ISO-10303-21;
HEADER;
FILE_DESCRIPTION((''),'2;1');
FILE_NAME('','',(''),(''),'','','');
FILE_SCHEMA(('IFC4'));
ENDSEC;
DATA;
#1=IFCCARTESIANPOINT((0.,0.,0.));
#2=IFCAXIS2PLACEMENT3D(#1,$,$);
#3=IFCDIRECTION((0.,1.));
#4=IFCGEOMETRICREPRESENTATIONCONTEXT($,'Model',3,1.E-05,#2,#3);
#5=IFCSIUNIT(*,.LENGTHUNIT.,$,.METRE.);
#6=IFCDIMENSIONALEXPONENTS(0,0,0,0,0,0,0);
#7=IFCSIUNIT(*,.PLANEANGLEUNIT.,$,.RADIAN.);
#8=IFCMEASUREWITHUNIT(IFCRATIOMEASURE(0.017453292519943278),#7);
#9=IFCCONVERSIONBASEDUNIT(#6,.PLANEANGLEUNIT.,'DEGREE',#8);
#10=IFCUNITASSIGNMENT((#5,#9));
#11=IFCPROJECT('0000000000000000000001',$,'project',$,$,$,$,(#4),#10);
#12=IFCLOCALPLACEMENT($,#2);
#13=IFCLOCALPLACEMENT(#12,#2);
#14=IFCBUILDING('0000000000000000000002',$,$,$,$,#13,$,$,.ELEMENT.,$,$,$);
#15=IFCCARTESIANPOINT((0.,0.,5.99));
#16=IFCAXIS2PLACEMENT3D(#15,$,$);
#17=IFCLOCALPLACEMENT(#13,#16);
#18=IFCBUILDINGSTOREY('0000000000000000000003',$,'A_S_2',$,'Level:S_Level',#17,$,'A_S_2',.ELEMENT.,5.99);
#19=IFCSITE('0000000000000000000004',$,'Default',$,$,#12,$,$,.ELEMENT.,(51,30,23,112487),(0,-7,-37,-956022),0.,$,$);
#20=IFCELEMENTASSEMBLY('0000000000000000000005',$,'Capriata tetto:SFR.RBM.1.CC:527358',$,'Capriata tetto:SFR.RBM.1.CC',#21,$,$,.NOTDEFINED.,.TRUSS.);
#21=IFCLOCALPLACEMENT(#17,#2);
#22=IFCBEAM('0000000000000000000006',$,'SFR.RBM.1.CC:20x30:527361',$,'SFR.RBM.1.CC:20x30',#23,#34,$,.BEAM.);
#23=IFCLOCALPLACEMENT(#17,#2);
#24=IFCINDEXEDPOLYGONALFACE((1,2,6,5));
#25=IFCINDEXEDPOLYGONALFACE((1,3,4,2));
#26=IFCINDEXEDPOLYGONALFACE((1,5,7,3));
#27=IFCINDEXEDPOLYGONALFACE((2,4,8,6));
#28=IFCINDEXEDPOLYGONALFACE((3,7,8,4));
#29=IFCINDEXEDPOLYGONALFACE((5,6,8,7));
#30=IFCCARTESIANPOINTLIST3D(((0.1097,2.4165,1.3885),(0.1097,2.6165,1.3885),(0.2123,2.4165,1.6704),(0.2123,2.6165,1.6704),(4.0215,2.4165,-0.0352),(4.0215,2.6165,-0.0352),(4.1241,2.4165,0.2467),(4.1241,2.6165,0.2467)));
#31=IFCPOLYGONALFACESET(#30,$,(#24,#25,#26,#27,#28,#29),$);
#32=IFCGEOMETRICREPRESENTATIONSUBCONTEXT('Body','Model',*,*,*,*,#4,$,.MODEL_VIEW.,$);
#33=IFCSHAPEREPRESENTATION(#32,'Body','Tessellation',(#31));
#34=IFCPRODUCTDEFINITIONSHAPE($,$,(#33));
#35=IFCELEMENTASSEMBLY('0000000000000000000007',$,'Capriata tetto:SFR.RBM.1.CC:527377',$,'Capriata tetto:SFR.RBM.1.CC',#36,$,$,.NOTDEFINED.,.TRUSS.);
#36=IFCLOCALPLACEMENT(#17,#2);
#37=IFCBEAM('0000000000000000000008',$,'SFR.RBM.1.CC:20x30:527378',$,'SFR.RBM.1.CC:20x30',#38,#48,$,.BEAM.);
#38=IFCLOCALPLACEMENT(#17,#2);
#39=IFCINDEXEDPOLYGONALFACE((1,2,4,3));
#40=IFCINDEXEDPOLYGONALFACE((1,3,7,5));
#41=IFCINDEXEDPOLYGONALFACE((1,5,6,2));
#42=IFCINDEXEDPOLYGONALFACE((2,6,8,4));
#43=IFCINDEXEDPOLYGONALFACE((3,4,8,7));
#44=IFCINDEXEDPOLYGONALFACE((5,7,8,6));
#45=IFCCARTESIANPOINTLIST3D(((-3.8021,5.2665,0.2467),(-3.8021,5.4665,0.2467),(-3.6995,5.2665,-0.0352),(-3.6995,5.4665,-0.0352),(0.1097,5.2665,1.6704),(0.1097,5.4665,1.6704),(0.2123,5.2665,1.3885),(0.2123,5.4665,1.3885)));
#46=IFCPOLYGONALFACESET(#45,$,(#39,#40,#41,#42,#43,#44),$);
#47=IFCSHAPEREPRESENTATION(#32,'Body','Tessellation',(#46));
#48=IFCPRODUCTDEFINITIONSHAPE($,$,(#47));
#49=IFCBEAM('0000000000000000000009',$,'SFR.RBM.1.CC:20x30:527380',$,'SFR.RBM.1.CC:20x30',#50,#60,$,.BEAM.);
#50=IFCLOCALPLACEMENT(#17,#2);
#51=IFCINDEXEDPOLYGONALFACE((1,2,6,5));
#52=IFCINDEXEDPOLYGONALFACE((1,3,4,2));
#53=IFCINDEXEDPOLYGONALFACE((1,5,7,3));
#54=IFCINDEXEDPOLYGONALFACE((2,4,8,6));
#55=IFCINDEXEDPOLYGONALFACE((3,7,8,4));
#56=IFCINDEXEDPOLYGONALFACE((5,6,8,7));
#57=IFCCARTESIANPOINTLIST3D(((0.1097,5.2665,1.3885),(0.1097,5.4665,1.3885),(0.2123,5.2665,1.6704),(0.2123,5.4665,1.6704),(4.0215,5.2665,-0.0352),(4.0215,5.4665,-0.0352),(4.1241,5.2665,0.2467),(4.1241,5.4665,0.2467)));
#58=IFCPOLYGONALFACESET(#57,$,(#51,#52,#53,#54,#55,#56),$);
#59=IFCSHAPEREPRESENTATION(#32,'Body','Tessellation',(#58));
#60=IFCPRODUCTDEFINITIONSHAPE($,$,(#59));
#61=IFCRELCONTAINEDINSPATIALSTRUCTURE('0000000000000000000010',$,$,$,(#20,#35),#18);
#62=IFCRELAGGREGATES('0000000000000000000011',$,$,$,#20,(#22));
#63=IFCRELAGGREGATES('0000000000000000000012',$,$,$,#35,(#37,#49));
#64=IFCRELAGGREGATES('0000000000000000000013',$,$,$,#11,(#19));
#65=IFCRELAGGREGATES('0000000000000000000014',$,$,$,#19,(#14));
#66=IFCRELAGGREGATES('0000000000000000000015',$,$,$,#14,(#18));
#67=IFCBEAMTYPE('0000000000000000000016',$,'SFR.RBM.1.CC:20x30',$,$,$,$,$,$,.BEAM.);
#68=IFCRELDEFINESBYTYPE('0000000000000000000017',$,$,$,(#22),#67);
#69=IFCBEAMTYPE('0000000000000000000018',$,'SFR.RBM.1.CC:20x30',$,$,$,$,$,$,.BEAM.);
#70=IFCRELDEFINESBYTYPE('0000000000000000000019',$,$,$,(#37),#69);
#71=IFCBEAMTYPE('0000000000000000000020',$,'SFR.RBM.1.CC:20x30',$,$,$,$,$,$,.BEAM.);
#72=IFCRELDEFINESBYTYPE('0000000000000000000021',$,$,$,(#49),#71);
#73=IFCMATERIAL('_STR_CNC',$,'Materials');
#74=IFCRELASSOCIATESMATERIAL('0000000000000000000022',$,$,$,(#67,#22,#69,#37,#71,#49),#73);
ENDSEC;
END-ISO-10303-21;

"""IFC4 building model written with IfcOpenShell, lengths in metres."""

from ifc_helpers import new_model, entity, si_unit, converted_unit, direction, frame, origin, place, context, subcontext, project, spatial, indexed_curve, outline, extrude, source, transform, mapped, material, type_object, type_shapes, element, aggregate, save


model = new_model("IFC4")

# Units and contexts
model_context = context("Model", 3, precision=1e-05, world=origin(), true_north=direction((0.0, 1.0)))
body_context = subcontext(model_context, "Body", "Model", "MODEL_VIEW")
ifc_project = project(units=[si_unit("LENGTHUNIT", "METRE"), converted_unit("PLANEANGLEUNIT", "DEGREE", entity("IfcRatioMeasure", 0.017453292519943278), si_unit("PLANEANGLEUNIT", "RADIAN"), dimensions=[0, 0, 0, 0, 0, 0, 0])], contexts=[model_context])

# Site, building, storey
site_placement = place(None, origin())
site = spatial("IfcSite", under=ifc_project, at=site_placement, Name="Default", CompositionType="ELEMENT", RefLatitude=(51, 30, 23, 112487), RefLongitude=(0, -7, -37, -956022), RefElevation=0.0)
building_placement = place(site_placement, origin())
building = spatial("IfcBuilding", under=site, at=building_placement, CompositionType="ELEMENT")
storey_placement = place(building_placement, frame((0.0, 0.0, 5.99)))
storey = spatial("IfcBuildingStorey", under=building, at=storey_placement, Name="A_S_2", ObjectType="Level:S_Level", LongName="A_S_2", CompositionType="ELEMENT", Elevation=5.99)

# Shared definitions
ifc_material_1 = material(Name="_STR_CNC", Category="Materials")

# Element assemblies, beams
assembly_1_placement = place(storey_placement, origin())
assembly_1 = element("IfcElementAssembly", 1, at=assembly_1_placement, inside=storey, Name="Capriata tetto:SFR.RBM.1.CC:527358", ObjectType="Capriata tetto:SFR.RBM.1.CC", AssemblyPlace="NOTDEFINED", PredefinedType="TRUSS")
beam_type_1 = type_object("IfcBeamType", Name="SFR.RBM.1.CC:20x30", PredefinedType="BEAM", material=ifc_material_1)
shared_shape_1 = source(origin(), body_context, "Body", "SweptSolid", [
    extrude(outline(indexed_curve([(-0.1, -0.15), (0.1, -0.15), (0.1, 0.15), (-0.1, 0.15), (-0.1, -0.15)], self_intersect=False)), frame((0.161, 2.5165, 7.5195), z_axis=(0.939693, 0.0, -0.34202), x_axis=(0.0, 1.0, 0.0)), (0.0, 0.0, 1.0), 4.1628),
])
type_shapes(beam_type_1, [shared_shape_1])
beam_1_placement = place(assembly_1_placement, frame((0.0, 0.0, -5.99)))
beam_1 = element("IfcBeam", 2, at=beam_1_placement, type_object=beam_type_1, material=ifc_material_1, Name="SFR.RBM.1.CC:20x30:527361", ObjectType="SFR.RBM.1.CC:20x30", PredefinedType="BEAM", context=body_context, shape_type="MappedRepresentation", body=[
    mapped(shared_shape_1, transform((0.0, 0.0, 0.0), scale=1.0)),
])
aggregate(assembly_1, [beam_1])
assembly_2_placement = place(storey_placement, origin())
assembly_2 = element("IfcElementAssembly", 3, at=assembly_2_placement, inside=storey, Name="Capriata tetto:SFR.RBM.1.CC:527377", ObjectType="Capriata tetto:SFR.RBM.1.CC", AssemblyPlace="NOTDEFINED", PredefinedType="TRUSS")
beam_type_2 = type_object("IfcBeamType", Name="SFR.RBM.1.CC:20x30", PredefinedType="BEAM", material=ifc_material_1)
shared_shape_2 = source(origin(), body_context, "Body", "SweptSolid", [
    extrude(outline(indexed_curve([(-0.1, -0.15), (0.1, -0.15), (0.1, 0.15), (-0.1, 0.15), (-0.1, -0.15)], self_intersect=False)), frame((-3.7508, 5.3665, 6.0957), z_axis=(0.939693, 0.0, 0.34202), x_axis=(0.0, -1.0, 0.0)), (0.0, 0.0, 1.0), 4.1628),
])
type_shapes(beam_type_2, [shared_shape_2])
beam_2_placement = place(assembly_2_placement, frame((0.0, 0.0, -5.99)))
beam_2 = element("IfcBeam", 4, at=beam_2_placement, type_object=beam_type_2, material=ifc_material_1, Name="SFR.RBM.1.CC:20x30:527378", ObjectType="SFR.RBM.1.CC:20x30", PredefinedType="BEAM", context=body_context, shape_type="MappedRepresentation", body=[
    mapped(shared_shape_2, transform((0.0, 0.0, 0.0), scale=1.0)),
])
beam_type_3 = type_object("IfcBeamType", Name="SFR.RBM.1.CC:20x30", PredefinedType="BEAM", material=ifc_material_1)
shared_shape_3 = source(origin(), body_context, "Body", "SweptSolid", [
    extrude(outline(indexed_curve([(-0.1, -0.15), (0.1, -0.15), (0.1, 0.15), (-0.1, 0.15), (-0.1, -0.15)], self_intersect=False)), frame((0.161, 5.3665, 7.5195), z_axis=(0.939693, 0.0, -0.34202), x_axis=(0.0, 1.0, 0.0)), (0.0, 0.0, 1.0), 4.1628),
])
type_shapes(beam_type_3, [shared_shape_3])
beam_3_placement = place(assembly_2_placement, frame((0.0, 0.0, -5.99)))
beam_3 = element("IfcBeam", 5, at=beam_3_placement, type_object=beam_type_3, material=ifc_material_1, Name="SFR.RBM.1.CC:20x30:527380", ObjectType="SFR.RBM.1.CC:20x30", PredefinedType="BEAM", context=body_context, shape_type="MappedRepresentation", body=[
    mapped(shared_shape_3, transform((0.0, 0.0, 0.0), scale=1.0)),
])
aggregate(assembly_2, [beam_2, beam_3])

save(model, "model.ifc")
